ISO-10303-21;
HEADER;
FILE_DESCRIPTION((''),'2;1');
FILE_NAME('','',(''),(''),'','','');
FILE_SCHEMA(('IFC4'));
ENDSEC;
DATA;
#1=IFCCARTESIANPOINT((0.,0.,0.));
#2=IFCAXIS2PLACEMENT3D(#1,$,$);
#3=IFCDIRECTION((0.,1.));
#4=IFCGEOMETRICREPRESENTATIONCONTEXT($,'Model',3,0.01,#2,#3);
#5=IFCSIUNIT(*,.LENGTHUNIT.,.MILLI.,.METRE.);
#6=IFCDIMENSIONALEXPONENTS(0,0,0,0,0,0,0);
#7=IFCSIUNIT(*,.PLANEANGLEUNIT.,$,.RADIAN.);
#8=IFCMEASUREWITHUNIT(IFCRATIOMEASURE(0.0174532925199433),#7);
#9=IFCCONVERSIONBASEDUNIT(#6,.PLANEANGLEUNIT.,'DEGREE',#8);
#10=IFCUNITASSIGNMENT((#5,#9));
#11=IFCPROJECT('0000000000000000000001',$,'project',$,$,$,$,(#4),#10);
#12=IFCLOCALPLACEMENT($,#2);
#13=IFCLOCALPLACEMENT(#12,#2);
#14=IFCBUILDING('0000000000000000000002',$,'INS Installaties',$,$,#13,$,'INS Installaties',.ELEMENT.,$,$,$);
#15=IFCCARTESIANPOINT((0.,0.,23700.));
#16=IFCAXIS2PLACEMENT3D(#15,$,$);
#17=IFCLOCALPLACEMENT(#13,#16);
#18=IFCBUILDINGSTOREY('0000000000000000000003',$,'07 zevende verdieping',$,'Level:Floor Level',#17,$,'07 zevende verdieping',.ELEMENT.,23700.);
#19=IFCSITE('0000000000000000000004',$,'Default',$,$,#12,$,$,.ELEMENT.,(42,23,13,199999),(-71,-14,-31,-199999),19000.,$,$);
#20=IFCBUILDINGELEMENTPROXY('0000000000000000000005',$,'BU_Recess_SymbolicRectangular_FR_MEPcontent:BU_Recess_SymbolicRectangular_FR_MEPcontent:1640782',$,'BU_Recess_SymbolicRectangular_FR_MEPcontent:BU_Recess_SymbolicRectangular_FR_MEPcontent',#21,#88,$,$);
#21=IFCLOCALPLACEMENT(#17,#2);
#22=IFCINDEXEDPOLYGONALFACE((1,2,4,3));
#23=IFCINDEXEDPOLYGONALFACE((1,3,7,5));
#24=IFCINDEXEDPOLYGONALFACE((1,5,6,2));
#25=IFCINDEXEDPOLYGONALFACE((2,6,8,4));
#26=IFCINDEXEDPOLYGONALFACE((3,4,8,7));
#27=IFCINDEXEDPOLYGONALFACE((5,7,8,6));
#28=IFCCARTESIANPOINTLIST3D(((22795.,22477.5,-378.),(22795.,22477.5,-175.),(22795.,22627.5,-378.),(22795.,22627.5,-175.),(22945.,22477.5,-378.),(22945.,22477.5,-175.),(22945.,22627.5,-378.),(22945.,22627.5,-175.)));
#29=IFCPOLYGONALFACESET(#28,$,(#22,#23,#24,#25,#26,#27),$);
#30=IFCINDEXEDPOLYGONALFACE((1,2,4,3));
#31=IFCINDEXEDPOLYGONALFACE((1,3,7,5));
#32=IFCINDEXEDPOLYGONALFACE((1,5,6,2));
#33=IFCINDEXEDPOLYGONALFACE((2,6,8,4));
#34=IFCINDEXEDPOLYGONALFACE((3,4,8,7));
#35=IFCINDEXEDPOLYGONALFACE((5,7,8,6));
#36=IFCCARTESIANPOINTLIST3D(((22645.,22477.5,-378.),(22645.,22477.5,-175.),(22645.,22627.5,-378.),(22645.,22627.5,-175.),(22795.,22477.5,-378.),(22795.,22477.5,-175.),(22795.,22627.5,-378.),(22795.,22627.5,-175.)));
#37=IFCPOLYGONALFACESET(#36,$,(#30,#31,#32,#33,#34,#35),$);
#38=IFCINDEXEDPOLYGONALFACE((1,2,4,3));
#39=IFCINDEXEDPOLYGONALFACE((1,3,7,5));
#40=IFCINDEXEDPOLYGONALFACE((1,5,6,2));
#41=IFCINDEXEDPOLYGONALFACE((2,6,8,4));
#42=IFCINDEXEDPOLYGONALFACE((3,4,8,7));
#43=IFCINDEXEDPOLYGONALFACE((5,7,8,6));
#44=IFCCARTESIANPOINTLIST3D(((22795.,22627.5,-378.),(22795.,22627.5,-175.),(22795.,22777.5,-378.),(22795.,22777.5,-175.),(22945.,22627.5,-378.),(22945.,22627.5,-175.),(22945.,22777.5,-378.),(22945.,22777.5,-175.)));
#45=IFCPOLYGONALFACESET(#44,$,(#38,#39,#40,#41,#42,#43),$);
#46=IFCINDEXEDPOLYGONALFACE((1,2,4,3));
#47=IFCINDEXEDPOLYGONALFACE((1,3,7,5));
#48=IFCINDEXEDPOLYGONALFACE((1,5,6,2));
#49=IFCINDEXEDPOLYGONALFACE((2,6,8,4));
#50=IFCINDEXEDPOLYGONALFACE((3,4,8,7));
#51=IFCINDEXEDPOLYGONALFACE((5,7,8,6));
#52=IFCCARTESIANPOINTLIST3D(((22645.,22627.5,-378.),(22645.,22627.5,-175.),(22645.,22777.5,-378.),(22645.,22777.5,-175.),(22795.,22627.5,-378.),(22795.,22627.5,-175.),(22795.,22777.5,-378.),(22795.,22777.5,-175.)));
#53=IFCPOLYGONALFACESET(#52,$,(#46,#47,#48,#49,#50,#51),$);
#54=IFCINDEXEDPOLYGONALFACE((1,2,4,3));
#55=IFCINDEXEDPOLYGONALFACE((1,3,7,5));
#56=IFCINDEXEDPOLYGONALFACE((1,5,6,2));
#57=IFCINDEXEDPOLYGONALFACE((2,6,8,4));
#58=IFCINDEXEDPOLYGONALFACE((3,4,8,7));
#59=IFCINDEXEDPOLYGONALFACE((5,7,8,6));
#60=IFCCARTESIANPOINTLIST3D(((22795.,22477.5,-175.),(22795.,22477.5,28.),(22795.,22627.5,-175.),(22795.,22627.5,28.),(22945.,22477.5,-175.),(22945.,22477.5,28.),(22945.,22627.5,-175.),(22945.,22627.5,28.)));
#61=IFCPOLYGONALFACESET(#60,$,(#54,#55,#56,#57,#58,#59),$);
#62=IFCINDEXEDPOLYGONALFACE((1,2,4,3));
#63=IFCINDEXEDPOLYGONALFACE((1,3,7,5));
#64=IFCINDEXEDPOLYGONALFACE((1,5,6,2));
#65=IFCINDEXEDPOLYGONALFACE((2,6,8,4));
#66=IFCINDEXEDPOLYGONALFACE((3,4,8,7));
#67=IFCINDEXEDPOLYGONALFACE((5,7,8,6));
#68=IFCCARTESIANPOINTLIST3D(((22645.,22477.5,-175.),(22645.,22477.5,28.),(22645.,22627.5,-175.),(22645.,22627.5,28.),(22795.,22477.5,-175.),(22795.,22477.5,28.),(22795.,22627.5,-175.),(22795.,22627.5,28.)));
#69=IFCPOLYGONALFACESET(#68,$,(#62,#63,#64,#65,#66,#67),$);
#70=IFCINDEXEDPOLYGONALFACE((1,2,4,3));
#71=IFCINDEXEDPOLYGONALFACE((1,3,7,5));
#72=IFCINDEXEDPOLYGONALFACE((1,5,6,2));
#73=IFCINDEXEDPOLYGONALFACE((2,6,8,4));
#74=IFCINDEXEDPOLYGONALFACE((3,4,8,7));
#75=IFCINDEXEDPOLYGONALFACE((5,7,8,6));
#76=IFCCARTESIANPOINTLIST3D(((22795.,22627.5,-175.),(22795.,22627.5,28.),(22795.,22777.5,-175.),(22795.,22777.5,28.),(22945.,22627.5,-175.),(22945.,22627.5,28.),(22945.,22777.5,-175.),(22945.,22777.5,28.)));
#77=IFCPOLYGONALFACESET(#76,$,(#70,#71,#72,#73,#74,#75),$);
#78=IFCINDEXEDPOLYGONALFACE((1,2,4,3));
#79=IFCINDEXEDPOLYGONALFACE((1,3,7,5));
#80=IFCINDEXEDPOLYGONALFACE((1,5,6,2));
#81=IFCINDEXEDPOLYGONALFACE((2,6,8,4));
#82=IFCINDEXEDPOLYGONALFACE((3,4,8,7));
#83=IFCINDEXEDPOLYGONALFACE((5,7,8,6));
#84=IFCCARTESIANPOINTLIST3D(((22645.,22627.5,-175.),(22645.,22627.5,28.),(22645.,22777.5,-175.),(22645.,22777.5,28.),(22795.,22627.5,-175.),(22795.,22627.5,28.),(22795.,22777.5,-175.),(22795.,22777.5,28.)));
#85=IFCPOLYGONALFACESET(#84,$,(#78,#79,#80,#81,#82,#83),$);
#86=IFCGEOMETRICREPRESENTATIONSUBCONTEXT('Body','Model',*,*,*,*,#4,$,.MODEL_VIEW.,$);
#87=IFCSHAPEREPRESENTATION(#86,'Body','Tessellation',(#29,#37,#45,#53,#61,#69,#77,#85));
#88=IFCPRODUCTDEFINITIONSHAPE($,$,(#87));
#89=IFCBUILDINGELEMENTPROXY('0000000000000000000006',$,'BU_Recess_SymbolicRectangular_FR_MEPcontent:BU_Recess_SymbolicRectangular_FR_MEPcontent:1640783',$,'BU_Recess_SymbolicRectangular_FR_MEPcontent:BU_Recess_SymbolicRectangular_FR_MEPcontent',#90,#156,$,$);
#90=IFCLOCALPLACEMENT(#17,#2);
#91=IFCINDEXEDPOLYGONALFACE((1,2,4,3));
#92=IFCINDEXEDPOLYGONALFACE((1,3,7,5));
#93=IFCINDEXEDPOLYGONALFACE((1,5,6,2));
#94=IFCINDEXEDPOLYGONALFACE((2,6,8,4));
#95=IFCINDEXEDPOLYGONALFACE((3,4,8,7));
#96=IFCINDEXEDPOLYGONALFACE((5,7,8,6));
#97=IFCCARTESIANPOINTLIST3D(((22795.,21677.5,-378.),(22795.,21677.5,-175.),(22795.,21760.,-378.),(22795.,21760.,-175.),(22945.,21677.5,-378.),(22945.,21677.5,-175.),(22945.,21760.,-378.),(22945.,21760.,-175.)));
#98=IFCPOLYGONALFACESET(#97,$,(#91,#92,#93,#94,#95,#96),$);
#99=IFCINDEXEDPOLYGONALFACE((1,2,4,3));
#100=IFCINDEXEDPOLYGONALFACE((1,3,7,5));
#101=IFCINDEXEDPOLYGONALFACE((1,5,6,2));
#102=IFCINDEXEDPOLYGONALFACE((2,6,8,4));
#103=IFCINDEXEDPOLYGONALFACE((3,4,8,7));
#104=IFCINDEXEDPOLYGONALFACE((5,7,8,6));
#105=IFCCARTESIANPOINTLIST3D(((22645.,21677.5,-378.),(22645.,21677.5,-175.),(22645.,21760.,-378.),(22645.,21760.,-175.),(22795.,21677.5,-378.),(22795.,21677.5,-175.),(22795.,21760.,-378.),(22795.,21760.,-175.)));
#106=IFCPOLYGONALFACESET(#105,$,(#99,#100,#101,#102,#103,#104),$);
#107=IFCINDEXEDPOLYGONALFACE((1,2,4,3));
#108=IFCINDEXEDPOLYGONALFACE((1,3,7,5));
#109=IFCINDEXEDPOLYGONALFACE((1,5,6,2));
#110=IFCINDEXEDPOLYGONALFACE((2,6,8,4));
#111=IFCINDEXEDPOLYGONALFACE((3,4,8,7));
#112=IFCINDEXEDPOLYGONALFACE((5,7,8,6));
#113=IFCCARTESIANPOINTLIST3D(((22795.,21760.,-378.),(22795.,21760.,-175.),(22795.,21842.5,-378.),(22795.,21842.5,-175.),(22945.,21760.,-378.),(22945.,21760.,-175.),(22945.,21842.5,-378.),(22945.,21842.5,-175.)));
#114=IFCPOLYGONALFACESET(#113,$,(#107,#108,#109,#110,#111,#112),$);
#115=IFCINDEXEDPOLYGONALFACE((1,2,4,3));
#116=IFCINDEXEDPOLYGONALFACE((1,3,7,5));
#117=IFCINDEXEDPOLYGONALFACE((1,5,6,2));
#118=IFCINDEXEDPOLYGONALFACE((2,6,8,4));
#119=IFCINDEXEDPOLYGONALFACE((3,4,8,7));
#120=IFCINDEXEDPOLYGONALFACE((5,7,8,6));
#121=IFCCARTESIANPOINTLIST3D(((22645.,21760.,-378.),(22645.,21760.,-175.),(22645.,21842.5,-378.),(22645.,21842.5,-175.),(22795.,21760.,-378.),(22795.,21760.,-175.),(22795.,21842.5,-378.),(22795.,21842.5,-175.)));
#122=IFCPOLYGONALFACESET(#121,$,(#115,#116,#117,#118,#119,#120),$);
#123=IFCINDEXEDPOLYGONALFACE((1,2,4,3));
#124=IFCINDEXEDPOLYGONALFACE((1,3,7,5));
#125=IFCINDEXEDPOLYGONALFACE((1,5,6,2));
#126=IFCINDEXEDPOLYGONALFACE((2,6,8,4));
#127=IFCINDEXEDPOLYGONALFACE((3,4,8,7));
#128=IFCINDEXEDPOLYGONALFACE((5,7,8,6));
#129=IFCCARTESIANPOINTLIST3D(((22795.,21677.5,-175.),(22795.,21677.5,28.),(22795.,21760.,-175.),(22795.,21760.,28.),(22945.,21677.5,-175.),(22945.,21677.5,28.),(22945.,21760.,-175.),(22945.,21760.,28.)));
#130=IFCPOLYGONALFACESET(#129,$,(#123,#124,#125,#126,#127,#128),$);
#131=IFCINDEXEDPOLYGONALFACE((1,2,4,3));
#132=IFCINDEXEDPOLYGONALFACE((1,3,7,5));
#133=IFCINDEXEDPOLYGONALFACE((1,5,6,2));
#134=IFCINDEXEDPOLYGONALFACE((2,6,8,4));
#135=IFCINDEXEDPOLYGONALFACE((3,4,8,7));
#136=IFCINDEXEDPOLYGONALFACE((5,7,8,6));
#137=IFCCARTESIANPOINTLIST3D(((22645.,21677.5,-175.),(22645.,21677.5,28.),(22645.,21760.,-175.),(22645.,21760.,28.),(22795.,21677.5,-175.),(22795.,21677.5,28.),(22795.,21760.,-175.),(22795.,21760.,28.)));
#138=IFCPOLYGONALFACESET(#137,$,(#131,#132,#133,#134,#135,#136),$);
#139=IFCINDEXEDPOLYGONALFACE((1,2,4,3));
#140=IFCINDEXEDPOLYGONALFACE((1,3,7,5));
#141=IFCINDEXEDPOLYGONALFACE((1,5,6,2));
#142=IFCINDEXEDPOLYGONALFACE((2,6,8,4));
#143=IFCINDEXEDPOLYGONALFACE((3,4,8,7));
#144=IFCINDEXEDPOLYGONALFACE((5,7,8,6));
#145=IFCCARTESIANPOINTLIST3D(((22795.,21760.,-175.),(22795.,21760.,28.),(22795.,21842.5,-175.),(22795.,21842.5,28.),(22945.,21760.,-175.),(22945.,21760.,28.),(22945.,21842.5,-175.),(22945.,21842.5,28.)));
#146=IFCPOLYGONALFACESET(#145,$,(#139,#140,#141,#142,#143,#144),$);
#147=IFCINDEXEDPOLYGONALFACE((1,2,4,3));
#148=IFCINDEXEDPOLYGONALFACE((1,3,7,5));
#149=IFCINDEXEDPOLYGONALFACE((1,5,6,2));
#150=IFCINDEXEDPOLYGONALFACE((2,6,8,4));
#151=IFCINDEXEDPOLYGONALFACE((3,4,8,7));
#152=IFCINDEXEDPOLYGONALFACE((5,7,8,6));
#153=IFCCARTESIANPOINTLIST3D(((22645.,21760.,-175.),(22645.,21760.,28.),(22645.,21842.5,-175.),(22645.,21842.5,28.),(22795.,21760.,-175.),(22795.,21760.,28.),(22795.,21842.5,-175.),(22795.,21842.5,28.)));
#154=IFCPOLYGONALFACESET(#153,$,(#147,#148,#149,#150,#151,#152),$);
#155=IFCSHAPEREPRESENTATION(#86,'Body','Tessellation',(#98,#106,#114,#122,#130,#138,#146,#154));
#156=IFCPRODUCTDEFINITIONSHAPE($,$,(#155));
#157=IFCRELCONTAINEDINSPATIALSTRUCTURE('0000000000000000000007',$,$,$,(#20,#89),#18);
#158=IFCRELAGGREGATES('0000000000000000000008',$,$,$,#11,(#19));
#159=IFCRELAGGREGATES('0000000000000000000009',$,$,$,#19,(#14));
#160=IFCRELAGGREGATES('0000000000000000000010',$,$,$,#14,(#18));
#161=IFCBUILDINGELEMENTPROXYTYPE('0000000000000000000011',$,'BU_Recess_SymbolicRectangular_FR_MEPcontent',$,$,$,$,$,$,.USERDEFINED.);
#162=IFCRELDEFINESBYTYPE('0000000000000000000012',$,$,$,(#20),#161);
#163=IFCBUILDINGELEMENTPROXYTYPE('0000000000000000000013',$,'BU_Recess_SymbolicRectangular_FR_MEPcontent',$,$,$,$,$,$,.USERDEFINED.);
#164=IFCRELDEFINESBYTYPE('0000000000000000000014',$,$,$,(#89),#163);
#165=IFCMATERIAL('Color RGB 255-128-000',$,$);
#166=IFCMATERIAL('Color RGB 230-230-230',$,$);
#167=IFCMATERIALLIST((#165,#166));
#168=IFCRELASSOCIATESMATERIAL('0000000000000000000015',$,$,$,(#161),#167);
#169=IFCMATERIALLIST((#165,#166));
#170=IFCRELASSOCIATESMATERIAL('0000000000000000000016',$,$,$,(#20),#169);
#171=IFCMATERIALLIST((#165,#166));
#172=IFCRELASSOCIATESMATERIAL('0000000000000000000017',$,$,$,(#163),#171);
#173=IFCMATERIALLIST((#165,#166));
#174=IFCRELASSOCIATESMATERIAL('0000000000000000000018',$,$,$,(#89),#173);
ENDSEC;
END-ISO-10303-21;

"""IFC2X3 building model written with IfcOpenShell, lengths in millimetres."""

from ifc_helpers import new_model, entity, si_unit, converted_unit, direction, frame, frame_2d, origin, origin_2d_with_axis, place, context, subcontext, project, spatial, rectangle, extrude, source, transform, mapped, material, material_list, type_object, type_shapes, element, save


model = new_model("IFC2X3")

# Units and contexts
model_context = context("Model", 3, precision=0.01, world=origin(), true_north=direction((0.0, 1.0)))
body_context = subcontext(model_context, "Body", "Model", "MODEL_VIEW")
ifc_project = project(units=[si_unit("LENGTHUNIT", "METRE", prefix="MILLI"), converted_unit("PLANEANGLEUNIT", "DEGREE", entity("IfcRatioMeasure", 0.0174532925199433), si_unit("PLANEANGLEUNIT", "RADIAN"), dimensions=[0, 0, 0, 0, 0, 0, 0])], contexts=[model_context])

# Site, building, storey
site_placement = place(None, origin())
site = spatial("IfcSite", under=ifc_project, at=site_placement, Name="Default", CompositionType="ELEMENT", RefLatitude=(42, 23, 13, 199999), RefLongitude=(-71, -14, -31, -199999), RefElevation=19000.0)
building_placement = place(site_placement, origin())
building = spatial("IfcBuilding", under=site, at=building_placement, Name="INS Installaties", LongName="INS Installaties", CompositionType="ELEMENT")
storey_placement = place(building_placement, frame((0.0, 0.0, 23700.0)))
storey = spatial("IfcBuildingStorey", under=building, at=storey_placement, Name="07 zevende verdieping", ObjectType="Level:Floor Level", LongName="07 zevende verdieping", CompositionType="ELEMENT", Elevation=23700.0)

# Building element proxies
ifc_material_1 = material(Name="Color RGB 255-128-000")
ifc_material_2 = material(Name="Color RGB 230-230-230")
ifc_material_list_1 = material_list([ifc_material_1, ifc_material_2])
ifc_material_list_2 = material_list([ifc_material_1, ifc_material_2])
building_element_proxy_type_1 = type_object("IfcBuildingElementProxyType", Name="BU_Recess_SymbolicRectangular_FR_MEPcontent", PredefinedType="USERDEFINED", material=ifc_material_list_2)
shared_shape_1 = source(origin(), body_context, "Body", "SweptSolid", [
    extrude(rectangle(XDim=150.0, YDim=150.0, at=origin_2d_with_axis()), frame((75.0, -75.0, -403.0)), (0.0, 0.0, 1.0), 203.0),
    extrude(rectangle(XDim=150.0, YDim=150.0, at=origin_2d_with_axis()), frame((-75.0, -75.0, -403.0), z_axis=(0.0, 0.0, 1.0), x_axis=(0.0, 1.0, 0.0)), (0.0, 0.0, 1.0), 203.0),
    extrude(rectangle(XDim=150.0, YDim=150.0, at=origin_2d_with_axis()), frame((75.0, 75.0, -403.0), z_axis=(0.0, 0.0, 1.0), x_axis=(0.0, -1.0, 0.0)), (0.0, 0.0, 1.0), 203.0),
    extrude(rectangle(XDim=150.0, YDim=150.0, at=frame_2d((0.0, 0.0), x_axis=(1.0, 0.0))), frame((-75.0, 75.0, -403.0), z_axis=(0.0, 0.0, 1.0), x_axis=(-1.0, 0.0, 0.0)), (0.0, 0.0, 1.0), 203.0),
    extrude(rectangle(XDim=150.0, YDim=150.0, at=origin_2d_with_axis()), frame((75.0, -75.0, -200.0)), (0.0, 0.0, 1.0), 203.0),
    extrude(rectangle(XDim=150.0, YDim=150.0, at=origin_2d_with_axis()), frame((-75.0, -75.0, -200.0), z_axis=(0.0, 0.0, 1.0), x_axis=(0.0, 1.0, 0.0)), (0.0, 0.0, 1.0), 203.0),
    extrude(rectangle(XDim=150.0, YDim=150.0, at=frame_2d((0.0, 0.0), x_axis=(1.0, 0.0))), frame((75.0, 75.0, -200.0), z_axis=(0.0, 0.0, 1.0), x_axis=(0.0, -1.0, 0.0)), (0.0, 0.0, 1.0), 203.0),
    extrude(rectangle(XDim=150.0, YDim=150.0, at=frame_2d((0.0, 0.0), x_axis=(1.0, 0.0))), frame((-75.0, 75.0, -200.0), z_axis=(0.0, 0.0, 1.0), x_axis=(-1.0, 0.0, 0.0)), (0.0, 0.0, 1.0), 203.0),
])
type_shapes(building_element_proxy_type_1, [shared_shape_1])
proxy_1_placement = place(storey_placement, frame((22795.0, 22627.5, 25.0)))
element("IfcBuildingElementProxy", 1, at=proxy_1_placement, inside=storey, type_object=building_element_proxy_type_1, material=ifc_material_list_1, Name="BU_Recess_SymbolicRectangular_FR_MEPcontent:BU_Recess_SymbolicRectangular_FR_MEPcontent:1640782", ObjectType="BU_Recess_SymbolicRectangular_FR_MEPcontent:BU_Recess_SymbolicRectangular_FR_MEPcontent", context=body_context, shape_type="MappedRepresentation", body=[
    mapped(shared_shape_1, transform((0.0, 0.0, 0.0), scale=1.0)),
])
ifc_material_list_3 = material_list([ifc_material_1, ifc_material_2])
ifc_material_list_4 = material_list([ifc_material_1, ifc_material_2])
building_element_proxy_type_2 = type_object("IfcBuildingElementProxyType", Name="BU_Recess_SymbolicRectangular_FR_MEPcontent", PredefinedType="USERDEFINED", material=ifc_material_list_4)
shared_shape_2 = source(origin(), body_context, "Body", "SweptSolid", [
    extrude(rectangle(XDim=150.0, YDim=82.5, at=frame_2d((0.0, 0.0), x_axis=(1.0, 0.0))), frame((75.0, -41.2, -403.0)), (0.0, 0.0, 1.0), 203.0),
    extrude(rectangle(XDim=82.5, YDim=150.0, at=origin_2d_with_axis()), frame((-75.0, -41.2, -403.0), z_axis=(0.0, 0.0, 1.0), x_axis=(0.0, 1.0, 0.0)), (0.0, 0.0, 1.0), 203.0),
    extrude(rectangle(XDim=82.5, YDim=150.0, at=origin_2d_with_axis()), frame((75.0, 41.3, -403.0), z_axis=(0.0, 0.0, 1.0), x_axis=(0.0, -1.0, 0.0)), (0.0, 0.0, 1.0), 203.0),
    extrude(rectangle(XDim=150.0, YDim=82.5, at=frame_2d((0.0, 0.0), x_axis=(1.0, 0.0))), frame((-75.0, 41.3, -403.0), z_axis=(0.0, 0.0, 1.0), x_axis=(-1.0, 0.0, 0.0)), (0.0, 0.0, 1.0), 203.0),
    extrude(rectangle(XDim=150.0, YDim=82.5, at=frame_2d((0.0, 0.0), x_axis=(1.0, 0.0))), frame((75.0, -41.3, -200.0)), (0.0, 0.0, 1.0), 203.0),
    extrude(rectangle(XDim=82.5, YDim=150.0, at=origin_2d_with_axis()), frame((-75.0, -41.3, -200.0), z_axis=(0.0, 0.0, 1.0), x_axis=(0.0, 1.0, 0.0)), (0.0, 0.0, 1.0), 203.0),
    extrude(rectangle(XDim=82.5, YDim=150.0, at=frame_2d((0.0, 0.0), x_axis=(1.0, 0.0))), frame((75.0, 41.2, -200.0), z_axis=(0.0, 0.0, 1.0), x_axis=(0.0, -1.0, 0.0)), (0.0, 0.0, 1.0), 203.0),
    extrude(rectangle(XDim=150.0, YDim=82.5, at=frame_2d((0.0, 0.0), x_axis=(1.0, 0.0))), frame((-75.0, 41.2, -200.0), z_axis=(0.0, 0.0, 1.0), x_axis=(-1.0, 0.0, 0.0)), (0.0, 0.0, 1.0), 203.0),
])
type_shapes(building_element_proxy_type_2, [shared_shape_2])
proxy_2_placement = place(storey_placement, frame((22795.0, 21760.0, 25.0)))
element("IfcBuildingElementProxy", 2, at=proxy_2_placement, inside=storey, type_object=building_element_proxy_type_2, material=ifc_material_list_3, Name="BU_Recess_SymbolicRectangular_FR_MEPcontent:BU_Recess_SymbolicRectangular_FR_MEPcontent:1640783", ObjectType="BU_Recess_SymbolicRectangular_FR_MEPcontent:BU_Recess_SymbolicRectangular_FR_MEPcontent", context=body_context, shape_type="MappedRepresentation", body=[
    mapped(shared_shape_2, transform((0.0, 0.0, 0.0), scale=1.0)),
])

save(model, "model.ifc")
